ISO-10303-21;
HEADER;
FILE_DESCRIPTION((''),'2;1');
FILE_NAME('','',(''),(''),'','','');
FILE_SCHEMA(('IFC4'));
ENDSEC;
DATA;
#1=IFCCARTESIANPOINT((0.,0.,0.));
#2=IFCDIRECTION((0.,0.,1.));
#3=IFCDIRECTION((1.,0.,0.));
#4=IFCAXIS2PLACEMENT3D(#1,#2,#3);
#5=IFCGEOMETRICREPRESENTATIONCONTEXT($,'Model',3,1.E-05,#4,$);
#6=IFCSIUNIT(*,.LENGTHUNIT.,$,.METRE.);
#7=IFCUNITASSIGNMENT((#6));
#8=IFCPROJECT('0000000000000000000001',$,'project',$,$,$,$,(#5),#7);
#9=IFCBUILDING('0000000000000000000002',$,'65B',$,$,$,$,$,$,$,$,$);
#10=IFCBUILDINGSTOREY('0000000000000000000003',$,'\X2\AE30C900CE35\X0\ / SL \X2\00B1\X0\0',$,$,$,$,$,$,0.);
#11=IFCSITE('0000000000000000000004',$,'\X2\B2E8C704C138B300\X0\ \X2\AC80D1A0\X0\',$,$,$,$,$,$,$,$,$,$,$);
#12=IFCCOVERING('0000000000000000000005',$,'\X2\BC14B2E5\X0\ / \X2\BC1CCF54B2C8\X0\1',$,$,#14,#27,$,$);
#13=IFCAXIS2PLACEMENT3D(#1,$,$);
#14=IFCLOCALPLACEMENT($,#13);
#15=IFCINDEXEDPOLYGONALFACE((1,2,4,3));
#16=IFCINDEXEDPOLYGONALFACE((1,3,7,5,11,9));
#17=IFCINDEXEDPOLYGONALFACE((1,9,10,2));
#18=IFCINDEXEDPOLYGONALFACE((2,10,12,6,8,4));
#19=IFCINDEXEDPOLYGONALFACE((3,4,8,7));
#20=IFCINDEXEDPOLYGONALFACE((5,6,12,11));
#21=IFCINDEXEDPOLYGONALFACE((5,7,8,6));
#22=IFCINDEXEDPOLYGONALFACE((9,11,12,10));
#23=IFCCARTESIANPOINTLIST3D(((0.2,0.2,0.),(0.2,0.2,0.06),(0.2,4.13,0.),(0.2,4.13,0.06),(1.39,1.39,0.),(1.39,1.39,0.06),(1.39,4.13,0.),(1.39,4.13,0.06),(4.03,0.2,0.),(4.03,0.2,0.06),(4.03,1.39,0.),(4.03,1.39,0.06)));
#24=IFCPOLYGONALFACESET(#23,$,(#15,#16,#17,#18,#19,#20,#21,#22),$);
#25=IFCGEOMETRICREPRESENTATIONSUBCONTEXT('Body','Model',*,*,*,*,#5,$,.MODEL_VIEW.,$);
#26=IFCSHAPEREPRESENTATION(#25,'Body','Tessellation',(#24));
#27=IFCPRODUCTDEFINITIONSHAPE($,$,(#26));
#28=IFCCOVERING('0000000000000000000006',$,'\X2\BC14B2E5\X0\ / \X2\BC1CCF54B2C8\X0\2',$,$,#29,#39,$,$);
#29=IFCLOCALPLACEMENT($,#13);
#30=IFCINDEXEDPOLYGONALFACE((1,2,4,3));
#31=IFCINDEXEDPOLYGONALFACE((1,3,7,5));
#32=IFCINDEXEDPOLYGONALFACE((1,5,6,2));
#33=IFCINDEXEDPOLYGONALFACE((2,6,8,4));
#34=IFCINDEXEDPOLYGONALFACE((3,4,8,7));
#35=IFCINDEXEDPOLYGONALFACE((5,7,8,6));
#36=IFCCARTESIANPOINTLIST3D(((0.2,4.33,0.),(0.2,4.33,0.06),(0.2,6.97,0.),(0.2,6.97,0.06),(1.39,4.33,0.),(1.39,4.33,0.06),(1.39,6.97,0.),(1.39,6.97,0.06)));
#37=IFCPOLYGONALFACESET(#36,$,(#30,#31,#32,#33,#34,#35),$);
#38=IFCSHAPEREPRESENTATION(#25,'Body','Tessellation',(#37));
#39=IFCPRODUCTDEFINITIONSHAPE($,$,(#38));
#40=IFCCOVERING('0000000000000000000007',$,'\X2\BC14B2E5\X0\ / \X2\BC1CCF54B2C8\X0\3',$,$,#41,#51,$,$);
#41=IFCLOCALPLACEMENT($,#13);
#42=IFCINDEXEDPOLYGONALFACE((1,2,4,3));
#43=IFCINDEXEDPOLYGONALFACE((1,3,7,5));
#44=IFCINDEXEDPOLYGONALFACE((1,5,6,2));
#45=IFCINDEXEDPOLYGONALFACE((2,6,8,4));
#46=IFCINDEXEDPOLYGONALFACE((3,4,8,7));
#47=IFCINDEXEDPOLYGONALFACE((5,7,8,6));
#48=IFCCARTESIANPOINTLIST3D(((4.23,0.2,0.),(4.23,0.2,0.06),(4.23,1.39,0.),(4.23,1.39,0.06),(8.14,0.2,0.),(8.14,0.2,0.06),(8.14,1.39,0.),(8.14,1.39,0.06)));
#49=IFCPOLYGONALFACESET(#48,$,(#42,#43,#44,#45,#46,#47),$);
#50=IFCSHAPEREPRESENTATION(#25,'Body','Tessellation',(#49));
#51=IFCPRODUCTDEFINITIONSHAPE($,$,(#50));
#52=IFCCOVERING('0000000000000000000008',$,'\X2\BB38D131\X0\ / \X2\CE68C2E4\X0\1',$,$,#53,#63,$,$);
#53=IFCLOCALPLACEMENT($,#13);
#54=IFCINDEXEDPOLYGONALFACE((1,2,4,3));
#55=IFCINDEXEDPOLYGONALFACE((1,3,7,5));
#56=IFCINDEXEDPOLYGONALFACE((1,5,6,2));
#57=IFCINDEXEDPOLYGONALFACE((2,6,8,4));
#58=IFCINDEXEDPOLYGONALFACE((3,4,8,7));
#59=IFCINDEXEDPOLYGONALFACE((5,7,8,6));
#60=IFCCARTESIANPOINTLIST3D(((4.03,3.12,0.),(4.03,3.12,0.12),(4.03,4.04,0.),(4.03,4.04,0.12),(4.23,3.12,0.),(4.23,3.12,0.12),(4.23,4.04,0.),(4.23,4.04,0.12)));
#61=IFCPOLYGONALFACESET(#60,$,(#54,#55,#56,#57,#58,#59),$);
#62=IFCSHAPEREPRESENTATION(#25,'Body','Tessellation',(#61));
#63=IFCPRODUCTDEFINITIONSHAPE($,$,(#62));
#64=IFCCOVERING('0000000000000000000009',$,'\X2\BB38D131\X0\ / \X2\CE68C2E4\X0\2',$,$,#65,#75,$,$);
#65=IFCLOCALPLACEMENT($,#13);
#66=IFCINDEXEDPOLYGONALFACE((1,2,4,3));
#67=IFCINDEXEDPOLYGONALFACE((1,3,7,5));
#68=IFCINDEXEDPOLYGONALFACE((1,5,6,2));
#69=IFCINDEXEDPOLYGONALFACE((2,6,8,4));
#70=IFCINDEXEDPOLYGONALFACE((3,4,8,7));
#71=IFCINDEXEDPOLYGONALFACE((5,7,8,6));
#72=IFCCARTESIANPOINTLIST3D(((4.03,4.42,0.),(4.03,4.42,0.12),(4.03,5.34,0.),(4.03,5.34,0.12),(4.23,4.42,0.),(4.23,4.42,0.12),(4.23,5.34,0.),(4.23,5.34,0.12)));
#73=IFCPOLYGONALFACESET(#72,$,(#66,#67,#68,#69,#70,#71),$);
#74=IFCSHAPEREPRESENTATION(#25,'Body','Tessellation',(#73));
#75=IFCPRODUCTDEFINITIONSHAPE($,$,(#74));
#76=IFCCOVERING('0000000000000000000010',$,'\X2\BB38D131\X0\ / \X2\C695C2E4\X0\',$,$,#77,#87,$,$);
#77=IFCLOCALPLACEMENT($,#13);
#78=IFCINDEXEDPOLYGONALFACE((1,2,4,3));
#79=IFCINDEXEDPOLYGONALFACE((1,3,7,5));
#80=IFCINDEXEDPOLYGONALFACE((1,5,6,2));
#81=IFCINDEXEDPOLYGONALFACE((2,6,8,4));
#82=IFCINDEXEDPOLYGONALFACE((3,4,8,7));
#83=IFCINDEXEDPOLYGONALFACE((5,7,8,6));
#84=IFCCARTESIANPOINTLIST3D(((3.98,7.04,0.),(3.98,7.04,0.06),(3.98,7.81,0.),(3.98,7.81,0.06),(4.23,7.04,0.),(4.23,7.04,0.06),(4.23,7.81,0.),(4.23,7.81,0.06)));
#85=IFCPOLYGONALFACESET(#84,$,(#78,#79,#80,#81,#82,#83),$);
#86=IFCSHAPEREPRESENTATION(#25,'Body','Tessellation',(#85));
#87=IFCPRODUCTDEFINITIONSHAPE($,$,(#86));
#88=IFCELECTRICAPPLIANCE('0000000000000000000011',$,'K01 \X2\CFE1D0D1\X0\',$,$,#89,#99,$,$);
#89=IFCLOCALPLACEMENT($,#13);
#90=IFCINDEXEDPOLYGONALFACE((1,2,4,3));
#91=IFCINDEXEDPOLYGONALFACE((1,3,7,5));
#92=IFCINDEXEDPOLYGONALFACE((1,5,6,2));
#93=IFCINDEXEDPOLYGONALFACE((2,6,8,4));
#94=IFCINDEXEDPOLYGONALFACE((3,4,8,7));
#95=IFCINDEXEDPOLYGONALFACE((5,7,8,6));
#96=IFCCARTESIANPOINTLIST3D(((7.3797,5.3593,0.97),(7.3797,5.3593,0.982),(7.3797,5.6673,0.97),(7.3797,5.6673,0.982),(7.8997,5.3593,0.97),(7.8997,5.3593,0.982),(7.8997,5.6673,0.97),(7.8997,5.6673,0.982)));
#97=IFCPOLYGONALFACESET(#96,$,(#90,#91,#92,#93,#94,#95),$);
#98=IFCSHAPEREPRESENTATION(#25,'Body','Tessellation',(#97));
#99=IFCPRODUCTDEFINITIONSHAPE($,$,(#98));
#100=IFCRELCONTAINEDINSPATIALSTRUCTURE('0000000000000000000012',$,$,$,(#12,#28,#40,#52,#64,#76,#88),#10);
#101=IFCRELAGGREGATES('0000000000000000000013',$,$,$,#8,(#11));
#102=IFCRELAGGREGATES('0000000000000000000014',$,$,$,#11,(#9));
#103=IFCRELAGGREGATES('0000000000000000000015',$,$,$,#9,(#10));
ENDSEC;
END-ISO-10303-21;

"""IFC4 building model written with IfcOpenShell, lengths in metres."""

from ifc_helpers import new_model, si_unit, frame, origin, origin_with_axes, place, context, subcontext, project, spatial, polyline, outline, extrude, element, save


model = new_model("IFC4")

# Units and contexts
model_context = context("Model", 3, precision=1e-05, world=origin_with_axes())
body_context = subcontext(model_context, "Body", "Model", "MODEL_VIEW")
ifc_project = project(units=[si_unit("LENGTHUNIT", "METRE")], contexts=[model_context])

# Site, building, storey
site = spatial("IfcSite", under=ifc_project, Name="단위세대 검토")
building = spatial("IfcBuilding", under=site, Name="65B")
storey = spatial("IfcBuildingStorey", under=building, Name="기준층 / SL ±0", Elevation=0.0)

# Coverings
covering_1_placement = place(None, origin_with_axes())
element("IfcCovering", 1, at=covering_1_placement, inside=storey, Name="바닥 / 발코니1", context=body_context, shape_type="SweptSolid", body=[
    extrude(outline(polyline([(0.2, 0.2), (4.03, 0.2), (4.03, 1.39), (1.39, 1.39), (1.39, 4.13), (0.2, 4.13), (0.2, 0.2)])), origin(), (0.0, 0.0, 1.0), 0.06),
])
covering_2_placement = place(None, origin_with_axes())
element("IfcCovering", 2, at=covering_2_placement, inside=storey, Name="바닥 / 발코니2", context=body_context, shape_type="SweptSolid", body=[
    extrude(outline(polyline([(1.39, 4.33), (1.39, 6.97), (0.2, 6.97), (0.2, 4.33), (1.39, 4.33)])), origin(), (0.0, 0.0, 1.0), 0.06),
])
covering_3_placement = place(None, origin_with_axes())
element("IfcCovering", 3, at=covering_3_placement, inside=storey, Name="바닥 / 발코니3", context=body_context, shape_type="SweptSolid", body=[
    extrude(outline(polyline([(8.14, 0.2), (8.14, 1.39), (4.23, 1.39), (4.23, 0.2), (8.14, 0.2)])), origin(), (0.0, 0.0, 1.0), 0.06),
])
covering_4_placement = place(None, origin_with_axes())
element("IfcCovering", 4, at=covering_4_placement, inside=storey, Name="문턱 / 침실1", context=body_context, shape_type="SweptSolid", body=[
    extrude(outline(polyline([(4.23, 3.12), (4.23, 4.04), (4.03, 4.04), (4.03, 3.12), (4.23, 3.12)])), origin(), (0.0, 0.0, 1.0), 0.12),
])
covering_5_placement = place(None, origin_with_axes())
element("IfcCovering", 5, at=covering_5_placement, inside=storey, Name="문턱 / 침실2", context=body_context, shape_type="SweptSolid", body=[
    extrude(outline(polyline([(4.23, 4.42), (4.23, 5.34), (4.03, 5.34), (4.03, 4.42), (4.23, 4.42)])), origin(), (0.0, 0.0, 1.0), 0.12),
])
covering_6_placement = place(None, origin_with_axes())
element("IfcCovering", 6, at=covering_6_placement, inside=storey, Name="문턱 / 욕실", context=body_context, shape_type="SweptSolid", body=[
    extrude(outline(polyline([(4.23, 7.04), (4.23, 7.81), (3.98, 7.81), (3.98, 7.04), (4.23, 7.04)])), origin(), (0.0, 0.0, 1.0), 0.06),
])

# Electric appliance
electric_appliance_1_placement = place(None, origin_with_axes())
element("IfcElectricAppliance", 7, at=electric_appliance_1_placement, inside=storey, Name="K01 쿡탑", context=body_context, shape_type="SweptSolid", body=[
    extrude(outline(polyline([(7.8997, 5.6673), (7.8997, 5.3593), (7.3797, 5.3593), (7.3797, 5.6673), (7.8997, 5.6673)])), frame((0.0, 0.0, 0.97)), (0.0, 0.0, 1.0), 0.012),
])

save(model, "model.ifc")
